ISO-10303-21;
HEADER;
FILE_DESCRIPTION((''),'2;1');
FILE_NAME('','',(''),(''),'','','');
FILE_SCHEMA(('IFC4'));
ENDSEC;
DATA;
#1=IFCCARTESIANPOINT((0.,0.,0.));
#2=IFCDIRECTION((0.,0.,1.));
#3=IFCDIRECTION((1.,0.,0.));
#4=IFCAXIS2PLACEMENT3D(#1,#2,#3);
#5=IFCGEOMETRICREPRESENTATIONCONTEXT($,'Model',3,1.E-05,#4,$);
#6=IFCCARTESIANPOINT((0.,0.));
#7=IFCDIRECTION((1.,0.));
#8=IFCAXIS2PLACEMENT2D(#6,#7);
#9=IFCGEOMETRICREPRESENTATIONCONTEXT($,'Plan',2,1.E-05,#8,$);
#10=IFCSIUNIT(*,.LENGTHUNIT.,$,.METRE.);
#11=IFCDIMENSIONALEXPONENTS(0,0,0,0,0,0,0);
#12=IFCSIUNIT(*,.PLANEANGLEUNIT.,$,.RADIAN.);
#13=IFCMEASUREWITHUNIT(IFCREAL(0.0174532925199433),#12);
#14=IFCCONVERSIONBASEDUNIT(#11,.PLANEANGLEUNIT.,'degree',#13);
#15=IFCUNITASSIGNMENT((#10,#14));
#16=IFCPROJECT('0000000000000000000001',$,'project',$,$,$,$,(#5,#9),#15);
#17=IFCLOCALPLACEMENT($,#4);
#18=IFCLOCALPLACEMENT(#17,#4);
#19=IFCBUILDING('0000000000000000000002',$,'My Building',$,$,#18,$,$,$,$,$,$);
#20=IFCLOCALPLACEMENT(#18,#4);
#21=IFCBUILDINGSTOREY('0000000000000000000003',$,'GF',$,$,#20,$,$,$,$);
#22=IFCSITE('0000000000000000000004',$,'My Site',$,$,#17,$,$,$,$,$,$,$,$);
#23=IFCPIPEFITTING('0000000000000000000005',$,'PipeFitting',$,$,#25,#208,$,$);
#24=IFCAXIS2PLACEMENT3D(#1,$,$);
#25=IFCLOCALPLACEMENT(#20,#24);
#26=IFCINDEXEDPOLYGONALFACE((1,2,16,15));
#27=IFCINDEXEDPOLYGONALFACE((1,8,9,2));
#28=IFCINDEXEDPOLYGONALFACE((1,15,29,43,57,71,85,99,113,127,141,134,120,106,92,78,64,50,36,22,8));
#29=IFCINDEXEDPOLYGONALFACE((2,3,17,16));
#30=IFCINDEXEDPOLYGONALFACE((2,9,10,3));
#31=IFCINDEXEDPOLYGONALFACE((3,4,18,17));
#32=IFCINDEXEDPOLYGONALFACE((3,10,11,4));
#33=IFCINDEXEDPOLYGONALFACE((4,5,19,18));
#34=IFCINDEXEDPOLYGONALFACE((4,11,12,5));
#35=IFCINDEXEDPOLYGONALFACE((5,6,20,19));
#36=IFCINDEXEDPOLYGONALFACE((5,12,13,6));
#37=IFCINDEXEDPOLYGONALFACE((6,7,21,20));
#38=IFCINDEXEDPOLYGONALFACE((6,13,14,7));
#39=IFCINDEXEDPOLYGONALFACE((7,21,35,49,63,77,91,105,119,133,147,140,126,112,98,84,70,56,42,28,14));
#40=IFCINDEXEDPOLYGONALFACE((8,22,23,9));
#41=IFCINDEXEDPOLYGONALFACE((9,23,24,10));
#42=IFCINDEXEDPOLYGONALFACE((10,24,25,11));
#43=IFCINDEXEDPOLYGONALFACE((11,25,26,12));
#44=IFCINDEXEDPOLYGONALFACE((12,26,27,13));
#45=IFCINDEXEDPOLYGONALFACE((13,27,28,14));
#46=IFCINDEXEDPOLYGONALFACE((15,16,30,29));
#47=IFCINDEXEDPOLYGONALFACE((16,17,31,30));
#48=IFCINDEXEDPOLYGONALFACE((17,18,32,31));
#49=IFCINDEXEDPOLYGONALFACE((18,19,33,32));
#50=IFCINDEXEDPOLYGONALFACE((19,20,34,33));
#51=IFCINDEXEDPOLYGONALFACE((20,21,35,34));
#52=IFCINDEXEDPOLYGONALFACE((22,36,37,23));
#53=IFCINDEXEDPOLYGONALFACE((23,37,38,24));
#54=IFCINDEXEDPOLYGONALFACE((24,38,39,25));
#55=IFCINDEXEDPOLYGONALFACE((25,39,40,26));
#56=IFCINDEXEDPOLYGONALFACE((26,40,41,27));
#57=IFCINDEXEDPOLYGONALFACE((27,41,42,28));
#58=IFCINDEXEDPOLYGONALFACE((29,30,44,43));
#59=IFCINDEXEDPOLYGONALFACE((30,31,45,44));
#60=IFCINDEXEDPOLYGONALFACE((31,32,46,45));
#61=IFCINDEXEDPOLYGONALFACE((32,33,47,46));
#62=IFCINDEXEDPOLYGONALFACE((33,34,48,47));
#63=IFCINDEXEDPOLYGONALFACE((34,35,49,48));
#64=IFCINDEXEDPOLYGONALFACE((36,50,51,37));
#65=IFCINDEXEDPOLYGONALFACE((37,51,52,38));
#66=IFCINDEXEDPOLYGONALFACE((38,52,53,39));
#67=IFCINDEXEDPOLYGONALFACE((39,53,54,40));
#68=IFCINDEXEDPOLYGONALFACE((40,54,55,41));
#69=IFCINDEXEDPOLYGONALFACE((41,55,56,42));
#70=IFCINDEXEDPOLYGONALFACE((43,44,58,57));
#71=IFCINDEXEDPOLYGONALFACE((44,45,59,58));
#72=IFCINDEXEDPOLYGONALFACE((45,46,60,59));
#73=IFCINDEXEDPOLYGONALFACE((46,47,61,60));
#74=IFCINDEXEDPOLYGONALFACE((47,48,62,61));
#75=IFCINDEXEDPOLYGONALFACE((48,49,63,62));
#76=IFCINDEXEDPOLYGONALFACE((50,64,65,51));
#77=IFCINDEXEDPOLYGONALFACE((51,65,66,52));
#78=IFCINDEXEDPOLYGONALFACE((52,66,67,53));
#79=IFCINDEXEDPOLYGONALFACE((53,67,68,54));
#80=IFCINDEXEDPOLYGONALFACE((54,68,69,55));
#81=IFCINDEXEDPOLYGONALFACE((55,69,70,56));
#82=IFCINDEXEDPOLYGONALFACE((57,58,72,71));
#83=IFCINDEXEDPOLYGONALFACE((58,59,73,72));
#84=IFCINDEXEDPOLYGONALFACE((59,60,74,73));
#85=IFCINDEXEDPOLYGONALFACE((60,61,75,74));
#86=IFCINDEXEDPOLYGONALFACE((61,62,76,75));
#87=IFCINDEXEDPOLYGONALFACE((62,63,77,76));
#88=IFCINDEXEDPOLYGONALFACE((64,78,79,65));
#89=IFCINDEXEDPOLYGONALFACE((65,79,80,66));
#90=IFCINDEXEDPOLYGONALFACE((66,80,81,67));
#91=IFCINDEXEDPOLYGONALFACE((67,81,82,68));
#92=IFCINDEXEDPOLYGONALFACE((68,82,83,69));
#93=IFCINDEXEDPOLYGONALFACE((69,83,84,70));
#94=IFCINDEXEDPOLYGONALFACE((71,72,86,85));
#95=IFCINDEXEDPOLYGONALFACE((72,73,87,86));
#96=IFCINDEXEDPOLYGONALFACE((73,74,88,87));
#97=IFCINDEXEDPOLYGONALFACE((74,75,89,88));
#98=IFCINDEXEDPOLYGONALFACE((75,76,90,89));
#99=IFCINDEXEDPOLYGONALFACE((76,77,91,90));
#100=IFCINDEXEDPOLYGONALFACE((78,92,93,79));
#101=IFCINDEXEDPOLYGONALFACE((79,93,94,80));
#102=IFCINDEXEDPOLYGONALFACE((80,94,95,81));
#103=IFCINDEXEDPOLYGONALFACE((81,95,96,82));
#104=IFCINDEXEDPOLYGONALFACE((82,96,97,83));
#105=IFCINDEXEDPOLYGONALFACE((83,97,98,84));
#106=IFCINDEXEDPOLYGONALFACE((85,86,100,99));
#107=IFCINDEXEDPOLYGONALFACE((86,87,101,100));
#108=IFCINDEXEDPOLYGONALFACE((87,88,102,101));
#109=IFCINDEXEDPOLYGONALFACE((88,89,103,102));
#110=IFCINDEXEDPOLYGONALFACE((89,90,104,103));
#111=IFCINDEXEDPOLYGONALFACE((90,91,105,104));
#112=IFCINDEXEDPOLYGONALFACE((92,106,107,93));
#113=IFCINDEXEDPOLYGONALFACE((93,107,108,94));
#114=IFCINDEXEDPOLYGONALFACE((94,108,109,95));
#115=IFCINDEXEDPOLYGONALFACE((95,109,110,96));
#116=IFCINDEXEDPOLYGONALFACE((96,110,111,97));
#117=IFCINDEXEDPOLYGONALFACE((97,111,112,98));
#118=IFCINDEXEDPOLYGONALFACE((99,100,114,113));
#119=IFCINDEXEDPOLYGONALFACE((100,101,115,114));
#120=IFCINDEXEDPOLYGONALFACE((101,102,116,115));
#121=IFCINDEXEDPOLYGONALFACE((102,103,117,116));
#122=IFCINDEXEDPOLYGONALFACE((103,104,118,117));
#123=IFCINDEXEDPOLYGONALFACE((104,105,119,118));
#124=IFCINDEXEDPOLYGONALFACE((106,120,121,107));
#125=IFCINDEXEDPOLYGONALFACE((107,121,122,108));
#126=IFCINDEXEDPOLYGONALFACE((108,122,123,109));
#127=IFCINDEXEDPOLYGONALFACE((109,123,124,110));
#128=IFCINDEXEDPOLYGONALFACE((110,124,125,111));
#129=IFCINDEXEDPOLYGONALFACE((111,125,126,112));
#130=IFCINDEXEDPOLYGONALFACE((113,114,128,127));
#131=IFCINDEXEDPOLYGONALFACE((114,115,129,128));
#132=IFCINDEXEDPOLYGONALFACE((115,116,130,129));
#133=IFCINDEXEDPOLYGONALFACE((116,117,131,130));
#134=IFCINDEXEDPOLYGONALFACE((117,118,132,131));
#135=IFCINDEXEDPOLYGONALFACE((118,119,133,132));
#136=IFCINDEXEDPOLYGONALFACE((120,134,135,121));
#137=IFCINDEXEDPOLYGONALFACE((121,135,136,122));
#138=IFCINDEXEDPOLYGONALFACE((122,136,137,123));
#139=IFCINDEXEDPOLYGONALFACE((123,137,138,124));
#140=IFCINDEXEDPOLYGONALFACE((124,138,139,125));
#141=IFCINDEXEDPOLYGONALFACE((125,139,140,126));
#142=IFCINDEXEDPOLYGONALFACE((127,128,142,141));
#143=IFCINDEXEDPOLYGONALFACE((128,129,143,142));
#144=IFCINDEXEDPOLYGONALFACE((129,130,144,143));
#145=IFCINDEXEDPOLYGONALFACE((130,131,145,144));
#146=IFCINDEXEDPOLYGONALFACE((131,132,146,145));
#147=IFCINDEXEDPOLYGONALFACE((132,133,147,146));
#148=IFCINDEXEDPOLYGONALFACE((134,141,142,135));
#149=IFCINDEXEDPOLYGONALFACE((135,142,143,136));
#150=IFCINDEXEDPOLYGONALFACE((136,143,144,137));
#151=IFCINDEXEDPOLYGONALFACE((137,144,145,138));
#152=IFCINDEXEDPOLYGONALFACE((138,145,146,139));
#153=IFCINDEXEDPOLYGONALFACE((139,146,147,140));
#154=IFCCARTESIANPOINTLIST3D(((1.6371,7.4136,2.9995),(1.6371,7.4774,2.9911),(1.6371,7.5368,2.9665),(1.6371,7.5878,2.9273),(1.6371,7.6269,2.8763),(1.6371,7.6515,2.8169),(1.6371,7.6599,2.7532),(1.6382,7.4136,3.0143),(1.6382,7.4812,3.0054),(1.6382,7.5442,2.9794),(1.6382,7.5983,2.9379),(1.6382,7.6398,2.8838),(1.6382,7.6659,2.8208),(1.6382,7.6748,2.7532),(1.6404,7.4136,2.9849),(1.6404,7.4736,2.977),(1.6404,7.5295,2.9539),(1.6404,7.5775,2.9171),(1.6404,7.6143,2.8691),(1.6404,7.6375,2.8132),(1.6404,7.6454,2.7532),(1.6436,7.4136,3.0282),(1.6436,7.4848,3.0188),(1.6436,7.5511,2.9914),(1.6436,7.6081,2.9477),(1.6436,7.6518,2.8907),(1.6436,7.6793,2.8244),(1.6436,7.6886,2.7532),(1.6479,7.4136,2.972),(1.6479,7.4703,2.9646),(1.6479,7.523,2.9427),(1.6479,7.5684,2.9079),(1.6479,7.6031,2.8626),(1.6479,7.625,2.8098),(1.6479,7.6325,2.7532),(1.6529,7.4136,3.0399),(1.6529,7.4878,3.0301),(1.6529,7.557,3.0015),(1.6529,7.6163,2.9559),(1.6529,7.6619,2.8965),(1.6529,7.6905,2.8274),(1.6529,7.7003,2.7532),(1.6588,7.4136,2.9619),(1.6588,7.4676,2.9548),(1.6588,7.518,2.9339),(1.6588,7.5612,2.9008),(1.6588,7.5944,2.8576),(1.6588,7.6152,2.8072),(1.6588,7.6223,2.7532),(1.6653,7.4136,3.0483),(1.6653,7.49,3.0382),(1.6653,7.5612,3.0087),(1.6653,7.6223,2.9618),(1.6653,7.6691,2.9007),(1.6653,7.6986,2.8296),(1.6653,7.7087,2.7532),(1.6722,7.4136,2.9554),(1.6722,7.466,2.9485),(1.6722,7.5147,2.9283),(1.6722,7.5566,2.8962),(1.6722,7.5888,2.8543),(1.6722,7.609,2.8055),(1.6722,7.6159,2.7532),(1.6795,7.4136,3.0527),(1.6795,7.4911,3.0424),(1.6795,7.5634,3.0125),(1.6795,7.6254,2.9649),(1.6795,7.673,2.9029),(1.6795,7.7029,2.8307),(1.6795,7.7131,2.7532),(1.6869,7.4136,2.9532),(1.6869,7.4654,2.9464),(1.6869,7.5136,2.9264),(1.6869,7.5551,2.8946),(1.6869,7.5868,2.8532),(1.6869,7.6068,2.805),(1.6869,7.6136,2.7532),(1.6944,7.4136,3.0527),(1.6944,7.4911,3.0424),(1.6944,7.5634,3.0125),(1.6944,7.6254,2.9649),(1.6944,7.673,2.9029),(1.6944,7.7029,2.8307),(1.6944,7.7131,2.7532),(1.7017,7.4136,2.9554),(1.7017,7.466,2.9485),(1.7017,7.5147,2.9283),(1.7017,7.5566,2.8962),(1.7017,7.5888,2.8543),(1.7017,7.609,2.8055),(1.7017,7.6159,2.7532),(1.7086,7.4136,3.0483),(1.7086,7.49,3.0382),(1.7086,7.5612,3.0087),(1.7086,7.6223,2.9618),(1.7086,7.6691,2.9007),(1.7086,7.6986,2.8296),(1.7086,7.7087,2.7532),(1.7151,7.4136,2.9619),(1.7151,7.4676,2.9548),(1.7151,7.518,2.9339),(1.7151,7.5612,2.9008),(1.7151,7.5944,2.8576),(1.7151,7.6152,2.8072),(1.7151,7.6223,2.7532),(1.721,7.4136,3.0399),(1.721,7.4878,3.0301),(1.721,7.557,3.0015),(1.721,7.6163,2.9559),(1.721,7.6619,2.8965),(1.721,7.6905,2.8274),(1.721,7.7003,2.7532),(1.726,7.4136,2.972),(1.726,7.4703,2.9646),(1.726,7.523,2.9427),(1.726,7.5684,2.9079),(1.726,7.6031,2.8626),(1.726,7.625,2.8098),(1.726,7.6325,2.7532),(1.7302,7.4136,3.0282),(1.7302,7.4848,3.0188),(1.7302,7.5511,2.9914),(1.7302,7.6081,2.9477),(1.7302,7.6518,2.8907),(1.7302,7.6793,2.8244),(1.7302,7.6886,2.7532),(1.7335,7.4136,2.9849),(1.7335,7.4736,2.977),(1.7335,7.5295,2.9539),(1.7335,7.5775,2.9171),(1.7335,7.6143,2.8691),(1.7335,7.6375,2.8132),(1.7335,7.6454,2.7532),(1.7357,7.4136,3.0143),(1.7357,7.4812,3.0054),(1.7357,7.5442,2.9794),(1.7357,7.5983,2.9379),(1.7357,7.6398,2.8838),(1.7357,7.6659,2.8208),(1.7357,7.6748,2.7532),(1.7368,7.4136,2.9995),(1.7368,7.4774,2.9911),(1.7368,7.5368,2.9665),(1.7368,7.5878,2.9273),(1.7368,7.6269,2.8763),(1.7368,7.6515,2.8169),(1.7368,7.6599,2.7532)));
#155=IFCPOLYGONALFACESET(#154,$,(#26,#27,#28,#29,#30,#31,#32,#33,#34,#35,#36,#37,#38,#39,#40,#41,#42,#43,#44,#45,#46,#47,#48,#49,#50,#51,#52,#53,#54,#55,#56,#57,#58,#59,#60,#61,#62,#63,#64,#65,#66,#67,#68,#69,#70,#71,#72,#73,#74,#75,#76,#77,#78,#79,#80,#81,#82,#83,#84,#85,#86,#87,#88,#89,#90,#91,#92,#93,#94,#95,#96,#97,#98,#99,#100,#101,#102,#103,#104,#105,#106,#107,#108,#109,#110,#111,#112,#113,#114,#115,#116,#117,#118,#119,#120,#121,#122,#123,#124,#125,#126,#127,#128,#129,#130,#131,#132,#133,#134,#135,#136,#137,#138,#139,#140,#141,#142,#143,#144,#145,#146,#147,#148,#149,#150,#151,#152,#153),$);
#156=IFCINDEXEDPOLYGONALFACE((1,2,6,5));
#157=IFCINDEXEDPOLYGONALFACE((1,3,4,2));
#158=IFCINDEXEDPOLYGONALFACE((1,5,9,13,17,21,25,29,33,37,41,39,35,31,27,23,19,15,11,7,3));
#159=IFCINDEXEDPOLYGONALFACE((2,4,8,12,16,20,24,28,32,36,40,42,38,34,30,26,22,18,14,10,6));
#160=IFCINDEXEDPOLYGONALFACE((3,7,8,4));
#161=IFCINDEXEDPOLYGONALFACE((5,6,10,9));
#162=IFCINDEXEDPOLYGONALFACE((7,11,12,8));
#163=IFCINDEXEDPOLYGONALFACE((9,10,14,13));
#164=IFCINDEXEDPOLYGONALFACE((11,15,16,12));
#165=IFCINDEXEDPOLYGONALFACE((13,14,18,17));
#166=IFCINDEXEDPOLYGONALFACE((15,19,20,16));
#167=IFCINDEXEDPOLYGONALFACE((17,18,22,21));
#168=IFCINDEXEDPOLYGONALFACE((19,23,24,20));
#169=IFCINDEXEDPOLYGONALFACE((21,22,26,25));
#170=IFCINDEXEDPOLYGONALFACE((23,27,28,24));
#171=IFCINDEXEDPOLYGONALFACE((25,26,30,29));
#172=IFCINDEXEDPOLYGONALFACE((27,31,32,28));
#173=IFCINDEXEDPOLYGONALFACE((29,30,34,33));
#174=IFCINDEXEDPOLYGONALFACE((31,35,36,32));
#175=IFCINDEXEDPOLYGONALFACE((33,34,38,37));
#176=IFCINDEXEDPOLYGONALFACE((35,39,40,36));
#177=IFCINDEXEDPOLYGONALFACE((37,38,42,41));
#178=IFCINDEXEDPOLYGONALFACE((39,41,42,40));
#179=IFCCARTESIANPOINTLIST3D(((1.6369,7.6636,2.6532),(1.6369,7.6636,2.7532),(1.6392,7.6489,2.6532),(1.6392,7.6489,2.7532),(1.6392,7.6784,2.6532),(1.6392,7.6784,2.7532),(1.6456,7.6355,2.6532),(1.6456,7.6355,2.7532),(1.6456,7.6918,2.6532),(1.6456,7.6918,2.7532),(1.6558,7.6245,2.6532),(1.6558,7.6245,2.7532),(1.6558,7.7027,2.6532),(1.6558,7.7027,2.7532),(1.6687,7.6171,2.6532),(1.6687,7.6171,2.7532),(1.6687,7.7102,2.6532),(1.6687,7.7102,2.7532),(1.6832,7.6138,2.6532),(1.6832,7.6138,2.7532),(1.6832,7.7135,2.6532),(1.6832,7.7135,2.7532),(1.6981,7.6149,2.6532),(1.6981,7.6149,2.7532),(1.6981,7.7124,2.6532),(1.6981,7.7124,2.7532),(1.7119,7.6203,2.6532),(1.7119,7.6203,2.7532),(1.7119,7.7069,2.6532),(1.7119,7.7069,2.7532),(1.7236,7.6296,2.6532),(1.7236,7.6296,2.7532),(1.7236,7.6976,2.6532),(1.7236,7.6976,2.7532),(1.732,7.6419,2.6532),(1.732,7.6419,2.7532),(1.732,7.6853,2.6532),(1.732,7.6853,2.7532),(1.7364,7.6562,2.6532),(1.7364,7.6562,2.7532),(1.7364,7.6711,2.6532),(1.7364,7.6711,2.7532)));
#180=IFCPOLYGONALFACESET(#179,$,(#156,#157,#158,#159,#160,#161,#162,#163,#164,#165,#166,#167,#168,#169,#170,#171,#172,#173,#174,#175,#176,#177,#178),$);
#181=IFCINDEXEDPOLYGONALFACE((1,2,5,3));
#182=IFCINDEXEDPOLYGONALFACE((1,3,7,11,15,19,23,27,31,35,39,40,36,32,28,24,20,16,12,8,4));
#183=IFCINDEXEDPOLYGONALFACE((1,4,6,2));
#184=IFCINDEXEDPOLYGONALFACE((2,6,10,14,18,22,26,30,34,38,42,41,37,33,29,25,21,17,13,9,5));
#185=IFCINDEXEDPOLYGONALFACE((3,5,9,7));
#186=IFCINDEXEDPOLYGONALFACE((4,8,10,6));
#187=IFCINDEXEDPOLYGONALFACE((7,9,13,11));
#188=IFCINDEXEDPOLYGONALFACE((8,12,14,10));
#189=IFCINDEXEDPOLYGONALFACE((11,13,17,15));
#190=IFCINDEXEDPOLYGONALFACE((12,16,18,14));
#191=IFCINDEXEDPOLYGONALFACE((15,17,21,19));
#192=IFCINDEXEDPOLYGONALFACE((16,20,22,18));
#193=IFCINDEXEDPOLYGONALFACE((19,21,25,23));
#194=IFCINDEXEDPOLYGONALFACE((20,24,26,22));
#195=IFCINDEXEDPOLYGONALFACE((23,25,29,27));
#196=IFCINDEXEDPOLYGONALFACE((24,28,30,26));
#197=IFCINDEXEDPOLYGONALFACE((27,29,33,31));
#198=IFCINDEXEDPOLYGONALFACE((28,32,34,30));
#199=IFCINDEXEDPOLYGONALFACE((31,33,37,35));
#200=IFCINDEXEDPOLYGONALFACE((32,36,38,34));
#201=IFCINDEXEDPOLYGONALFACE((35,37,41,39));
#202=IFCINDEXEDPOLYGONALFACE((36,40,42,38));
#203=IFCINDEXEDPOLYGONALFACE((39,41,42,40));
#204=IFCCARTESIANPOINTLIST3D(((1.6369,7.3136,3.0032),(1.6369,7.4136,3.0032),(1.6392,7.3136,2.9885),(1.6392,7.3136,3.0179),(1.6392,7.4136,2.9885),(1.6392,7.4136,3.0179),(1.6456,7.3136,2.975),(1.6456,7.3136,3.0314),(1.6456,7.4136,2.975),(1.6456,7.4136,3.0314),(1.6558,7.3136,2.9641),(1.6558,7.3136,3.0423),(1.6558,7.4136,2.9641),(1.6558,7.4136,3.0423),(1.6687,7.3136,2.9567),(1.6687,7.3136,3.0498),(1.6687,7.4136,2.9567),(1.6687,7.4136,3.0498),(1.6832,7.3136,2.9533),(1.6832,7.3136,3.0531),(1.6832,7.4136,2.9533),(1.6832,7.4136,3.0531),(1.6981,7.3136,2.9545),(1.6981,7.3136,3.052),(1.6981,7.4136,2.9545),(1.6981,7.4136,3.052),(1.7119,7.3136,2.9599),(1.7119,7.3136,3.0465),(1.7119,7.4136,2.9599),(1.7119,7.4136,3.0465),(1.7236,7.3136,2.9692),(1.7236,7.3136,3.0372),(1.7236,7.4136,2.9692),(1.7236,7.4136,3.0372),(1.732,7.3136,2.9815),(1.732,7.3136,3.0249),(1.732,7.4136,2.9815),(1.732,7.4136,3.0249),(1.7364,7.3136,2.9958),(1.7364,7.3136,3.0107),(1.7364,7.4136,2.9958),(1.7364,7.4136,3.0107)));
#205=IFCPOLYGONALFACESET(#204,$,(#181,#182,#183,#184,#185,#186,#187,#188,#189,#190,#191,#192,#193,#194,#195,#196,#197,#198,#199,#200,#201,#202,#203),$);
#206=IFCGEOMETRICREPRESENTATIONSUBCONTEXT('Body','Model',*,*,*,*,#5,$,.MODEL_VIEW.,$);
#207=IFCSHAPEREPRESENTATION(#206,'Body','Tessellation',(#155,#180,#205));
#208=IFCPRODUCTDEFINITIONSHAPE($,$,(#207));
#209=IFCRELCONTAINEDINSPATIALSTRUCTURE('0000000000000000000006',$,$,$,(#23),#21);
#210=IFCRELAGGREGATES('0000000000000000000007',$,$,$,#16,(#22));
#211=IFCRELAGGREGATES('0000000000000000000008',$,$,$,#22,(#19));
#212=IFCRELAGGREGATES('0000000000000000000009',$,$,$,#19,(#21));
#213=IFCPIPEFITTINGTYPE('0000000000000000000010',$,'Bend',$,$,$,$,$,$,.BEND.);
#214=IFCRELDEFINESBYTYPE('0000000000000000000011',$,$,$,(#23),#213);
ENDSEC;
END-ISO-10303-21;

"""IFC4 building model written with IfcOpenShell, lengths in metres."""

from ifc_helpers import new_model, entity, si_unit, converted_unit, frame, origin_with_axes, origin_2d_with_axis, place, context, subcontext, project, spatial, circle, extrude, source, transform, mapped, type_object, type_shapes, element, save


model = new_model("IFC4")

# Units and contexts
model_context = context("Model", 3, precision=1e-05, world=origin_with_axes())
plan_context = context("Plan", 2, precision=1e-05, world=origin_2d_with_axis())
body_context_1 = subcontext(model_context, "Body", "Model", "MODEL_VIEW")
ifc_project = project(units=[si_unit("LENGTHUNIT", "METRE"), converted_unit("PLANEANGLEUNIT", "degree", entity("IfcReal", 0.0174532925199433), si_unit("PLANEANGLEUNIT", "RADIAN"), dimensions=[0, 0, 0, 0, 0, 0, 0])], contexts=[model_context, plan_context])

# Site, building, storey
site_placement = place(None, origin_with_axes())
site = spatial("IfcSite", under=ifc_project, at=site_placement, Name="My Site")
building_placement = place(site_placement, origin_with_axes())
building = spatial("IfcBuilding", under=site, at=building_placement, Name="My Building")
storey_placement = place(building_placement, origin_with_axes())
storey = spatial("IfcBuildingStorey", under=building, at=storey_placement, Name="GF")

# Pipe fitting
pipe_fitting_type = type_object("IfcPipeFittingType", Name="Bend", PredefinedType="BEND")
shared_shape_1 = source(origin_with_axes(), body_context_1, "Body", "SolidModel", [
    entity("IfcSweptDiskSolid", entity("IfcIndexedPolyCurve", entity("IfcCartesianPointList3D", [[0.0, 0.0, -0.1], [0.0, -0.0732, -0.2768], [0.0, -0.25, -0.35]]), [entity("IfcArcIndex", [1, 2, 3])]), 0.05),
    extrude(circle(Radius=0.05), origin_with_axes(), (0.0, 0.0, -1.0), 0.1),
    extrude(circle(Radius=0.05), frame((0.0, -0.25, -0.35), z_axis=(0.0, -1.0, 0.0), x_axis=(1.0, 0.0, 0.0)), (0.0, 0.0, 1.0), 0.1),
])
type_shapes(pipe_fitting_type, [shared_shape_1])
pipe_fitting_1_placement = place(storey_placement, frame((1.6869, 7.6636, 2.6532), z_axis=(0.0, 0.0, -1.0), x_axis=(-1.0, 0.0, 0.0)))
element("IfcPipeFitting", 1, at=pipe_fitting_1_placement, inside=storey, type_object=pipe_fitting_type, Name="PipeFitting", context=body_context_1, shape_type="MappedRepresentation", body=[
    mapped(shared_shape_1, transform((0.0, 0.0, 0.0), x_axis=(1.0, 0.0, 0.0), y_axis=(0.0, 1.0, 0.0), z_axis=(0.0, 0.0, 1.0), scale=1.0)),
])

save(model, "model.ifc")
